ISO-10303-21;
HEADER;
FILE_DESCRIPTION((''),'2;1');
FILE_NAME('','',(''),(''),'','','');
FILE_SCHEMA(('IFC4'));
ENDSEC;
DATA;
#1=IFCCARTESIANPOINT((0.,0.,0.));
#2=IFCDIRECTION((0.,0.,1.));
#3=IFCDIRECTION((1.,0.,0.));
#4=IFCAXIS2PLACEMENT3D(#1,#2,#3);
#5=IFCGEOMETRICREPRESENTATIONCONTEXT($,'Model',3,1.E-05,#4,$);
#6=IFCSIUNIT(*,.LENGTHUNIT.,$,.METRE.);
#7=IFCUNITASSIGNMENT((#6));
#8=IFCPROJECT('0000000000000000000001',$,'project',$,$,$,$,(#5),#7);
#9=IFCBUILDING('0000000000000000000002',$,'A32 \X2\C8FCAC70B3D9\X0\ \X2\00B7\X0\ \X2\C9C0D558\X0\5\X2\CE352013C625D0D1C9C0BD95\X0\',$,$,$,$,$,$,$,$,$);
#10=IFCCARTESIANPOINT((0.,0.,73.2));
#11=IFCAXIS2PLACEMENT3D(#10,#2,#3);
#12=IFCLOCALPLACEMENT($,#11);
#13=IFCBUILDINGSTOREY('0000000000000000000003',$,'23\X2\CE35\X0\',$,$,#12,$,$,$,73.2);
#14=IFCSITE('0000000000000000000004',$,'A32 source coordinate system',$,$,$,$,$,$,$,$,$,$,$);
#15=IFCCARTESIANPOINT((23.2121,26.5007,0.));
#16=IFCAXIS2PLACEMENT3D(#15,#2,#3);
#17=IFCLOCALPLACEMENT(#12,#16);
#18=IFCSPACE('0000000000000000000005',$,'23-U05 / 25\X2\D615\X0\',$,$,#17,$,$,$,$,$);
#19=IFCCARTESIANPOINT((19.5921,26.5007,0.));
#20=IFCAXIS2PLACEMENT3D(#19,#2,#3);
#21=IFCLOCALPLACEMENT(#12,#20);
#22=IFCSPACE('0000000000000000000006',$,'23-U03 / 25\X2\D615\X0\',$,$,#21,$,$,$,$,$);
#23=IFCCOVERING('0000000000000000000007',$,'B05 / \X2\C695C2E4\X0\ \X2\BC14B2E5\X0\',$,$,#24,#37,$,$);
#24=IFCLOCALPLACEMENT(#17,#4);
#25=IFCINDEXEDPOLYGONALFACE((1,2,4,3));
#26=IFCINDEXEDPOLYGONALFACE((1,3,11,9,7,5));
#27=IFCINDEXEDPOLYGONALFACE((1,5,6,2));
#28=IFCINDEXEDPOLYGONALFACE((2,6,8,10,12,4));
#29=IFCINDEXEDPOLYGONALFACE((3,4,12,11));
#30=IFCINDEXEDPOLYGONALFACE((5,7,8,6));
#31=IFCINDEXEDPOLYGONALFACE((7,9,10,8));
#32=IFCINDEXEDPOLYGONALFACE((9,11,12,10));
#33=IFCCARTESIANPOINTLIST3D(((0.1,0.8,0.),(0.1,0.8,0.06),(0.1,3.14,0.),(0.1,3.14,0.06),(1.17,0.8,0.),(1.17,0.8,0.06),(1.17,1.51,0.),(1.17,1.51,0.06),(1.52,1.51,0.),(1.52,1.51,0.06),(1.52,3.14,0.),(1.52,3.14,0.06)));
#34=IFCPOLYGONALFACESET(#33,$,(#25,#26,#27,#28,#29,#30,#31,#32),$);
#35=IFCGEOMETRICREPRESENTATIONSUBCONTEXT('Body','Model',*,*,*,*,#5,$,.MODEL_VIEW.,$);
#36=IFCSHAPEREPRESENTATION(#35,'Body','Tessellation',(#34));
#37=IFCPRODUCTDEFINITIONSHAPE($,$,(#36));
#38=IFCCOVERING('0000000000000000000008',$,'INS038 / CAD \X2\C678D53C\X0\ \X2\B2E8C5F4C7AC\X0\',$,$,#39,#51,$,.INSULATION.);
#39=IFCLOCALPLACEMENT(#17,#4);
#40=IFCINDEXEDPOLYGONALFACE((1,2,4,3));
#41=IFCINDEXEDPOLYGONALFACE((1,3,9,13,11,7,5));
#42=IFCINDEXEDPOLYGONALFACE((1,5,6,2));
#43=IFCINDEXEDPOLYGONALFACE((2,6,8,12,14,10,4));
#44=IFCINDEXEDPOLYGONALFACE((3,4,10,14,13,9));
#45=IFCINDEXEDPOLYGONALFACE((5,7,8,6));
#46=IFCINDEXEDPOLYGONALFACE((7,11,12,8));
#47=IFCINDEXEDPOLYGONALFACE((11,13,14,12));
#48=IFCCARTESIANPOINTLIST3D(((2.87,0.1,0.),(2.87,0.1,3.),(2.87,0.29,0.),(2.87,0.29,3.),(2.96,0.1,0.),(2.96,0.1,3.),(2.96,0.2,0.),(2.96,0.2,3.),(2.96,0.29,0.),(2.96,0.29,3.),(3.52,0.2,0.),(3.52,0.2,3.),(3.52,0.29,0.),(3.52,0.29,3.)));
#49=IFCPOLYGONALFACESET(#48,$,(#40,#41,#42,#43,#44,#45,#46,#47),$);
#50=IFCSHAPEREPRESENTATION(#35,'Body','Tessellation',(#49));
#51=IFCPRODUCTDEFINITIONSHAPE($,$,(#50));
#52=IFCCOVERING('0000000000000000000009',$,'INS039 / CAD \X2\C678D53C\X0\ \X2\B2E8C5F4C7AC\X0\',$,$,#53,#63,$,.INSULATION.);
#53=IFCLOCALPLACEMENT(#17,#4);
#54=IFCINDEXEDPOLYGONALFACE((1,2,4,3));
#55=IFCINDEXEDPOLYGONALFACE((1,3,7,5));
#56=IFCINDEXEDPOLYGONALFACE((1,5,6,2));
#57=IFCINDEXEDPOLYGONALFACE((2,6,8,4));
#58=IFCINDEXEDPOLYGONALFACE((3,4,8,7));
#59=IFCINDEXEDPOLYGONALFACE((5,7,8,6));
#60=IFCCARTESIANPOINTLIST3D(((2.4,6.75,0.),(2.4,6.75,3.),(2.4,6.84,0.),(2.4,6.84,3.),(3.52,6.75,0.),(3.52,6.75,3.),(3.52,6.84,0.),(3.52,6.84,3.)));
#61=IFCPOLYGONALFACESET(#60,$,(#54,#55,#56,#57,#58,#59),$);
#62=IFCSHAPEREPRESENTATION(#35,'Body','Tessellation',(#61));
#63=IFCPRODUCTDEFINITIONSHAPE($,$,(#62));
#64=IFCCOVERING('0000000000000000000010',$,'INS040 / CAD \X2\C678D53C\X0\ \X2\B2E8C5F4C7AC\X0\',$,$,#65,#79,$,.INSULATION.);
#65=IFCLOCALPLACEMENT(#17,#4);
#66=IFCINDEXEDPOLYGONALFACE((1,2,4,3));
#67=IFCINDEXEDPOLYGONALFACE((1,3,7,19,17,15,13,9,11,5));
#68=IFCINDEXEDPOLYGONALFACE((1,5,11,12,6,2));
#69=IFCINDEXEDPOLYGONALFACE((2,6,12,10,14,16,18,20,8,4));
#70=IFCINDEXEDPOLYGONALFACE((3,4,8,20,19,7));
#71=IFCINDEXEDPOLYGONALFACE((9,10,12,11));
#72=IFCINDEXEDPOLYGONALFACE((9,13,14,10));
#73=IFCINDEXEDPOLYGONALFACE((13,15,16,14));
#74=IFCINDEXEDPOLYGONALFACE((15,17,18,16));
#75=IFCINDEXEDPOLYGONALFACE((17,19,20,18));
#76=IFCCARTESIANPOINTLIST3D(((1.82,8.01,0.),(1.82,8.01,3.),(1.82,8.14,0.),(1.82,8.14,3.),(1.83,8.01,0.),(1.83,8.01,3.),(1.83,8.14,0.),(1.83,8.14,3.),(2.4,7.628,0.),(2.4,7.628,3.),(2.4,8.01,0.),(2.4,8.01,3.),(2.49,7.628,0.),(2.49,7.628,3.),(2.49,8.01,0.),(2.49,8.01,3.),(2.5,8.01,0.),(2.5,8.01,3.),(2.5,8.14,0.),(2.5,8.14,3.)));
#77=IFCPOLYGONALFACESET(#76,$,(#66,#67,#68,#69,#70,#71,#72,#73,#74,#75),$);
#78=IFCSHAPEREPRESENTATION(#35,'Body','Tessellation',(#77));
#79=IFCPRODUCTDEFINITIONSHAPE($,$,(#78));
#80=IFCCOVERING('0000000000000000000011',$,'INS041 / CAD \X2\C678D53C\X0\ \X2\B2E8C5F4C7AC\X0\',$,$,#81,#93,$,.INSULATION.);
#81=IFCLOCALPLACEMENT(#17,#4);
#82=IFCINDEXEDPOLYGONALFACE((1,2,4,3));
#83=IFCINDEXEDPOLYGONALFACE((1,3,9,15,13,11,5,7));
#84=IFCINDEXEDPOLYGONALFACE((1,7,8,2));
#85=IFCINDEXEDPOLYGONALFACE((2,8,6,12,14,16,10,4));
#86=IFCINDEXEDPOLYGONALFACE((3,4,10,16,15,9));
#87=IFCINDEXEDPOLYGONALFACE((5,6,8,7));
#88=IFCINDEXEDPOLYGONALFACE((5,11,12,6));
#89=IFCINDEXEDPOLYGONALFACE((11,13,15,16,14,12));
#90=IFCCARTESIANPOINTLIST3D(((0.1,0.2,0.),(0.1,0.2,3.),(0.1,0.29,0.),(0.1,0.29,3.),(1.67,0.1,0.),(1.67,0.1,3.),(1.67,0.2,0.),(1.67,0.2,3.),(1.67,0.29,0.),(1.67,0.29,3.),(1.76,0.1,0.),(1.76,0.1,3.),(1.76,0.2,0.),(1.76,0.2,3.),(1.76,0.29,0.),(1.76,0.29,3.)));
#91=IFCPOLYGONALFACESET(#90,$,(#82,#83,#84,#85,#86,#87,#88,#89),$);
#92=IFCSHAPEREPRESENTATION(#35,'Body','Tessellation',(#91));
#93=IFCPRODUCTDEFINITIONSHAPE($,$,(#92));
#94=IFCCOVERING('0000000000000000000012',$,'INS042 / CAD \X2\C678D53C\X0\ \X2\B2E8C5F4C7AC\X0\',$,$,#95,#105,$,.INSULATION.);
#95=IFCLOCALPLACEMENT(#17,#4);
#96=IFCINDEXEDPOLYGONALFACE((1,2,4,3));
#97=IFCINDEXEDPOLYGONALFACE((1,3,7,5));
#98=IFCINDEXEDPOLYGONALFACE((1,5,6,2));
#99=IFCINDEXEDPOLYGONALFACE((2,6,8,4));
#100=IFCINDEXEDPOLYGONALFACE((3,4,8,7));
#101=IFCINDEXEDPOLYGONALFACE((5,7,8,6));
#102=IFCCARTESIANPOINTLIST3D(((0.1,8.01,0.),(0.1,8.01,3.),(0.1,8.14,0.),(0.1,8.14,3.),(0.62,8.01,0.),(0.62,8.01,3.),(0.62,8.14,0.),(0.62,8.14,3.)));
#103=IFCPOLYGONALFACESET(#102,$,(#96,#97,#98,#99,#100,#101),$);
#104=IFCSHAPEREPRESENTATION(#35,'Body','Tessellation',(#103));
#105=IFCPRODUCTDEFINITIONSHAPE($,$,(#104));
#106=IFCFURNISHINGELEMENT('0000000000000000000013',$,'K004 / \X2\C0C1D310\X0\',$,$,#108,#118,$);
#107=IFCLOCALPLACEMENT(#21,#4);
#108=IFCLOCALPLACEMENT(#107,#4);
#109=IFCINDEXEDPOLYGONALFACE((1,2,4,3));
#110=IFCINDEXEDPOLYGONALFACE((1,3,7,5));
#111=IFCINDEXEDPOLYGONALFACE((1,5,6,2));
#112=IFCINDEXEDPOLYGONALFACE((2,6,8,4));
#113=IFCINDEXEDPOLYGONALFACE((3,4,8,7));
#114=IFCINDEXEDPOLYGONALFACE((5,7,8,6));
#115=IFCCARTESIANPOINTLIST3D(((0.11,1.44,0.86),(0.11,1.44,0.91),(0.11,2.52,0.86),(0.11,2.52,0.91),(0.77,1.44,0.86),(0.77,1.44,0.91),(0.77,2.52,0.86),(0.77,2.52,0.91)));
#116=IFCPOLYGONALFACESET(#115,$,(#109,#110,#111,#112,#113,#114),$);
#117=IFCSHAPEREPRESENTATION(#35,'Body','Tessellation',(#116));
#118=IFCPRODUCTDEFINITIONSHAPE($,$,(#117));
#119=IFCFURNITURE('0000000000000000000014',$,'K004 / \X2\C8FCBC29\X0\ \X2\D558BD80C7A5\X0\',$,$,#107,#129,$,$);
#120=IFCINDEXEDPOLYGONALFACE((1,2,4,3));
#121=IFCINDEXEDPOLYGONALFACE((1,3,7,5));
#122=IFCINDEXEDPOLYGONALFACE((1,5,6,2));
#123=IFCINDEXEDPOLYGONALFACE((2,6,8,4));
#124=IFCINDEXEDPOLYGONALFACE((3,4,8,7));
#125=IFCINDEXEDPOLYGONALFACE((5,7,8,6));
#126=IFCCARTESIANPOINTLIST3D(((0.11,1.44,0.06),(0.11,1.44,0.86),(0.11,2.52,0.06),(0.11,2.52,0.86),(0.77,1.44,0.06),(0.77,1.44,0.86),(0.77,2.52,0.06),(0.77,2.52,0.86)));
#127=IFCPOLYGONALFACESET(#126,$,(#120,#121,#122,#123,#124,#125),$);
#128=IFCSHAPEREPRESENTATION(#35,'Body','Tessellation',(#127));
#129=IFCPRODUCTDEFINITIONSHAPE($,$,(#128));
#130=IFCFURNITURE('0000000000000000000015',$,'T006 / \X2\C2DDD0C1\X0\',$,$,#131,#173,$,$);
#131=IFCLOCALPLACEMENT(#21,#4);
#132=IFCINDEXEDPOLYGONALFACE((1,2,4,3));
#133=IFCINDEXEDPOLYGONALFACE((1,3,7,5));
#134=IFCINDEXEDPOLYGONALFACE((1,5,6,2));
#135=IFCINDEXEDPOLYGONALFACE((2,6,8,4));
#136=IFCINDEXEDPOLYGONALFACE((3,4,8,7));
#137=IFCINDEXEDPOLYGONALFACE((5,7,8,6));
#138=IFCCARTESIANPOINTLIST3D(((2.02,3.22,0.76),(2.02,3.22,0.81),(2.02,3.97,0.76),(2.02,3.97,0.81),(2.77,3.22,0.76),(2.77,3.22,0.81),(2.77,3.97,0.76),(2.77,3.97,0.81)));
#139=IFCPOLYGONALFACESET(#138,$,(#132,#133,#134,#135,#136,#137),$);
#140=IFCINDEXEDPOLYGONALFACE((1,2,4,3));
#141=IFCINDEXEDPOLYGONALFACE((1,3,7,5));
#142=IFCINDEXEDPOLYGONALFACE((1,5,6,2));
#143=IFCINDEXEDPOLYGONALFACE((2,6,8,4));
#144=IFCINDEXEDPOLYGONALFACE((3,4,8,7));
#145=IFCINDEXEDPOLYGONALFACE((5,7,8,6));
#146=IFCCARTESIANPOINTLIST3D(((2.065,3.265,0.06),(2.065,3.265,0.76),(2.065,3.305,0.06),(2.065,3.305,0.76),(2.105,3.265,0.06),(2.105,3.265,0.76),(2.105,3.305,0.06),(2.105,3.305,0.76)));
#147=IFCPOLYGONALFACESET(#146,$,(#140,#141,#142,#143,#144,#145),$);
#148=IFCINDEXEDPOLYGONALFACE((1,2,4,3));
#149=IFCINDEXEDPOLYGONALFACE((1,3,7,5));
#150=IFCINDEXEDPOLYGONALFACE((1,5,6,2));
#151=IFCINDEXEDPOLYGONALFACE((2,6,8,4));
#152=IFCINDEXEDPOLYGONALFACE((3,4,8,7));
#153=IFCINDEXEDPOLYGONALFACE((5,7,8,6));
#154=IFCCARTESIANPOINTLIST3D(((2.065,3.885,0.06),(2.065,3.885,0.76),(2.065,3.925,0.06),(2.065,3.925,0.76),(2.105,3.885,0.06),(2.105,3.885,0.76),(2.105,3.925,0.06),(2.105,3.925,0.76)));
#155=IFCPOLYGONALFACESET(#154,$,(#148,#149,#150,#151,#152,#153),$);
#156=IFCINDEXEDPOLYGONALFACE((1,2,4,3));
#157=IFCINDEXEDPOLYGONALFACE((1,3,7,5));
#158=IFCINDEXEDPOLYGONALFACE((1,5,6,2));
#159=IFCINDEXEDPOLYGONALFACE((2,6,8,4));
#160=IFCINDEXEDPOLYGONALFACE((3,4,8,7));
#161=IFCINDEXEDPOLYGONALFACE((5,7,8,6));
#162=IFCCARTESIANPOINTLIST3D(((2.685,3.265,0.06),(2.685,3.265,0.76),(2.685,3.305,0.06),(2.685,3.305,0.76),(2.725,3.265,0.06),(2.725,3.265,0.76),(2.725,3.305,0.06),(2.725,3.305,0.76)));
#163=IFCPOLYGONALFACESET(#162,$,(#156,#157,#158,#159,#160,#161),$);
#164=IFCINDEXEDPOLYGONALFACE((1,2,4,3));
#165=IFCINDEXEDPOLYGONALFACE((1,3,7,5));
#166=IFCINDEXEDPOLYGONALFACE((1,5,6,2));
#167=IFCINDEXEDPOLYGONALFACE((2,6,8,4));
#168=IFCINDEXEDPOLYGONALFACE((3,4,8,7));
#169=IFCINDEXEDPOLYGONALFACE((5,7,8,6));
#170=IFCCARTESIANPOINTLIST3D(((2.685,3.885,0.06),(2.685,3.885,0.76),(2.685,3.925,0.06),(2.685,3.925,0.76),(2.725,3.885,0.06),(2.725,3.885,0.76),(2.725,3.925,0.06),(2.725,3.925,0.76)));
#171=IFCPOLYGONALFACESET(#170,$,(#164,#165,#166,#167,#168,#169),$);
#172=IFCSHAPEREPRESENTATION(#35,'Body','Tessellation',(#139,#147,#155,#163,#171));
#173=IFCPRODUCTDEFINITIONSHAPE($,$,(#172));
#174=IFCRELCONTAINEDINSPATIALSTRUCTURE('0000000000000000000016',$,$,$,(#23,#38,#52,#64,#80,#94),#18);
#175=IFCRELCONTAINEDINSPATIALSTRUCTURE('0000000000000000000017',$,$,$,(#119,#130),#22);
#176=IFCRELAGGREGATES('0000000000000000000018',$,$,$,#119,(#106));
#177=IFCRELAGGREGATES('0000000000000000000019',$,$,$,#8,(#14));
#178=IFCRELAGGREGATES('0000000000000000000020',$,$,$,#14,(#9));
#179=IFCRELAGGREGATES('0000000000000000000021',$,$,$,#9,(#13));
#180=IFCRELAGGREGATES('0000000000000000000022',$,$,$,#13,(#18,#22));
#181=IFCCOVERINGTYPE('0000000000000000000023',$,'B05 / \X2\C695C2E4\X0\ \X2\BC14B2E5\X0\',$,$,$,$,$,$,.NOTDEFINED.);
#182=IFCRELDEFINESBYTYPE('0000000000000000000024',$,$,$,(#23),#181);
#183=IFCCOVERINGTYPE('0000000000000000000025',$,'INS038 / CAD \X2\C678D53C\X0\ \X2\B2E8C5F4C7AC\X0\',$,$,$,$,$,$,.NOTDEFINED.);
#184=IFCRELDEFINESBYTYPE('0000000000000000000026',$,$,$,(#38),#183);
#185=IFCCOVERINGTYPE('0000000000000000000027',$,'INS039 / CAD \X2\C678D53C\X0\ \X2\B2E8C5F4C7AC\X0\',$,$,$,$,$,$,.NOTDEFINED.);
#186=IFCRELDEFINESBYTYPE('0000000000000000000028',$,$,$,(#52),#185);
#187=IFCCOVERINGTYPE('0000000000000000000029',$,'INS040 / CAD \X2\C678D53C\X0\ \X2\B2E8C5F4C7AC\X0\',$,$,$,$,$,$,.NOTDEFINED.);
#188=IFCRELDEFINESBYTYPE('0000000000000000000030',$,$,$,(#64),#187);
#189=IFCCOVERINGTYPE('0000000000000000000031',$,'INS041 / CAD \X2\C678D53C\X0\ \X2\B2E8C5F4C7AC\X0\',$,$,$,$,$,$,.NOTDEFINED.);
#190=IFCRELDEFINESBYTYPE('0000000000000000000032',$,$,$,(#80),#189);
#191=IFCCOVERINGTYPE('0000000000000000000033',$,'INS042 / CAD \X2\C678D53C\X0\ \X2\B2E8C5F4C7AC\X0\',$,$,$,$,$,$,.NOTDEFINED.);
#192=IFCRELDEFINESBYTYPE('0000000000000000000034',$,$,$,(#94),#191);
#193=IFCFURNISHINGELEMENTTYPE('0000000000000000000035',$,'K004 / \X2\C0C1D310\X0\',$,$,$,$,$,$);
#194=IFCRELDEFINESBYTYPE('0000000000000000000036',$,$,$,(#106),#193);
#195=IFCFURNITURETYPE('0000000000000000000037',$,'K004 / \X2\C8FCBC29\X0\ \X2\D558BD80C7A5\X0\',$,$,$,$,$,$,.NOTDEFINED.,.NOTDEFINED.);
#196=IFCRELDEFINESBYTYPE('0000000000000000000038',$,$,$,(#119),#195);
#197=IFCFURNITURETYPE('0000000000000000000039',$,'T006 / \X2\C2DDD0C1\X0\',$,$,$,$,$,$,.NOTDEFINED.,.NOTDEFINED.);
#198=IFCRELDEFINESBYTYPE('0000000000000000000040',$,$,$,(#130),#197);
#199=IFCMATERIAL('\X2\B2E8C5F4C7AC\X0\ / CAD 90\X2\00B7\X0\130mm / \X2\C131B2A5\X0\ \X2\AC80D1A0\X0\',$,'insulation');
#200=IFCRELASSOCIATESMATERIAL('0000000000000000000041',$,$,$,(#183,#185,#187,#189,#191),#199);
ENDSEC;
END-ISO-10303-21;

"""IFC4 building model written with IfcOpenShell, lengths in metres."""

from ifc_helpers import new_model, si_unit, frame, origin, origin_with_axes, place, context, subcontext, project, spatial, polyline, outline, extrude, source, transform, mapped, material, type_object, type_shapes, element, aggregate, save


model = new_model("IFC4")

# Units and contexts
model_context = context("Model", 3, precision=1e-05, world=origin_with_axes())
body_context = subcontext(model_context, "Body", "Model", "MODEL_VIEW")
ifc_project = project(units=[si_unit("LENGTHUNIT", "METRE")], contexts=[model_context])

# Site, building, storey, space
storey_placement = place(None, frame((0.0, 0.0, 73.2), z_axis=(0.0, 0.0, 1.0), x_axis=(1.0, 0.0, 0.0)))
space_1_placement = place(storey_placement, frame((23.2121, 26.5007, 0.0), z_axis=(0.0, 0.0, 1.0), x_axis=(1.0, 0.0, 0.0)))
site = spatial("IfcSite", under=ifc_project, Name="A32 source coordinate system")
building = spatial("IfcBuilding", under=site, Name="A32 주거동 · 지하5층–옥탑지붕")
storey = spatial("IfcBuildingStorey", under=building, at=storey_placement, Name="23층", Elevation=73.2)
space_1 = spatial("IfcSpace", under=storey, at=space_1_placement, Name="23-U05 / 25형")

# Shared definitions
space_2_placement = place(storey_placement, frame((19.5921, 26.5007, 0.0), z_axis=(0.0, 0.0, 1.0), x_axis=(1.0, 0.0, 0.0)))
space_2 = spatial("IfcSpace", under=storey, at=space_2_placement, Name="23-U03 / 25형")

# Coverings
covering_type_1 = type_object("IfcCoveringType", Name="B05 / 욕실 바닥", PredefinedType="NOTDEFINED")
shared_shape_1 = source(origin(), body_context, "Body", "SweptSolid", [
    extrude(outline(polyline([(0.1, 3.14), (1.52, 3.14), (1.52, 1.51), (1.17, 1.51), (1.17, 0.8), (0.1, 0.8), (0.1, 3.14)])), origin(), (0.0, 0.0, 1.0), 0.06),
])
type_shapes(covering_type_1, [shared_shape_1])
covering_1_placement = place(space_1_placement, origin_with_axes())
element("IfcCovering", 1, at=covering_1_placement, inside=space_1, type_object=covering_type_1, Name="B05 / 욕실 바닥", context=body_context, shape_type="MappedRepresentation", body=[
    mapped(shared_shape_1, transform((0.0, 0.0, 0.0), scale=1.0)),
])
ifc_material = material(Name="단열재 / CAD 90·130mm / 성능 검토", Category="insulation")
covering_type_2 = type_object("IfcCoveringType", Name="INS038 / CAD 외피 단열재", PredefinedType="NOTDEFINED", material=ifc_material)
shared_shape_2 = source(origin(), body_context, "Body", "SweptSolid", [
    extrude(outline(polyline([(2.96, 0.2), (2.96, 0.1), (2.87, 0.1), (2.87, 0.29), (2.96, 0.29), (3.52, 0.29), (3.52, 0.2), (2.96, 0.2)])), origin(), (0.0, 0.0, 1.0), 3.0),
])
type_shapes(covering_type_2, [shared_shape_2])
covering_2_placement = place(space_1_placement, origin_with_axes())
element("IfcCovering", 2, at=covering_2_placement, inside=space_1, type_object=covering_type_2, Name="INS038 / CAD 외피 단열재", PredefinedType="INSULATION", context=body_context, shape_type="MappedRepresentation", body=[
    mapped(shared_shape_2, transform((0.0, 0.0, 0.0), scale=1.0)),
])
covering_type_3 = type_object("IfcCoveringType", Name="INS039 / CAD 외피 단열재", PredefinedType="NOTDEFINED", material=ifc_material)
shared_shape_3 = source(origin(), body_context, "Body", "SweptSolid", [
    extrude(outline(polyline([(2.4, 6.75), (2.4, 6.84), (3.52, 6.84), (3.52, 6.75), (2.4, 6.75)])), origin(), (0.0, 0.0, 1.0), 3.0),
])
type_shapes(covering_type_3, [shared_shape_3])
covering_3_placement = place(space_1_placement, origin_with_axes())
element("IfcCovering", 3, at=covering_3_placement, inside=space_1, type_object=covering_type_3, Name="INS039 / CAD 외피 단열재", PredefinedType="INSULATION", context=body_context, shape_type="MappedRepresentation", body=[
    mapped(shared_shape_3, transform((0.0, 0.0, 0.0), scale=1.0)),
])
covering_type_4 = type_object("IfcCoveringType", Name="INS040 / CAD 외피 단열재", PredefinedType="NOTDEFINED", material=ifc_material)
shared_shape_4 = source(origin(), body_context, "Body", "SweptSolid", [
    extrude(outline(polyline([(2.4, 7.628), (2.4, 8.01), (1.83, 8.01), (1.82, 8.01), (1.82, 8.14), (1.83, 8.14), (2.5, 8.14), (2.5, 8.01), (2.49, 8.01), (2.49, 7.628), (2.4, 7.628)])), origin(), (0.0, 0.0, 1.0), 3.0),
])
type_shapes(covering_type_4, [shared_shape_4])
covering_4_placement = place(space_1_placement, origin_with_axes())
element("IfcCovering", 4, at=covering_4_placement, inside=space_1, type_object=covering_type_4, Name="INS040 / CAD 외피 단열재", PredefinedType="INSULATION", context=body_context, shape_type="MappedRepresentation", body=[
    mapped(shared_shape_4, transform((0.0, 0.0, 0.0), scale=1.0)),
])
covering_type_5 = type_object("IfcCoveringType", Name="INS041 / CAD 외피 단열재", PredefinedType="NOTDEFINED", material=ifc_material)
shared_shape_5 = source(origin(), body_context, "Body", "SweptSolid", [
    extrude(outline(polyline([(1.67, 0.2), (0.1, 0.2), (0.1, 0.29), (1.67, 0.29), (1.76, 0.29), (1.76, 0.2), (1.76, 0.1), (1.67, 0.1), (1.67, 0.2)])), origin(), (0.0, 0.0, 1.0), 3.0),
])
type_shapes(covering_type_5, [shared_shape_5])
covering_5_placement = place(space_1_placement, origin_with_axes())
element("IfcCovering", 5, at=covering_5_placement, inside=space_1, type_object=covering_type_5, Name="INS041 / CAD 외피 단열재", PredefinedType="INSULATION", context=body_context, shape_type="MappedRepresentation", body=[
    mapped(shared_shape_5, transform((0.0, 0.0, 0.0), scale=1.0)),
])
covering_type_6 = type_object("IfcCoveringType", Name="INS042 / CAD 외피 단열재", PredefinedType="NOTDEFINED", material=ifc_material)
shared_shape_6 = source(origin(), body_context, "Body", "SweptSolid", [
    extrude(outline(polyline([(0.62, 8.14), (0.62, 8.01), (0.1, 8.01), (0.1, 8.14), (0.62, 8.14)])), origin(), (0.0, 0.0, 1.0), 3.0),
])
type_shapes(covering_type_6, [shared_shape_6])
covering_6_placement = place(space_1_placement, origin_with_axes())
element("IfcCovering", 6, at=covering_6_placement, inside=space_1, type_object=covering_type_6, Name="INS042 / CAD 외피 단열재", PredefinedType="INSULATION", context=body_context, shape_type="MappedRepresentation", body=[
    mapped(shared_shape_6, transform((0.0, 0.0, 0.0), scale=1.0)),
])

# Furnishing element
furnishing_element_type_1 = type_object("IfcFurnishingElementType", Name="K004 / 상판")
shared_shape_7 = source(origin(), body_context, "Body", "SweptSolid", [
    extrude(outline(polyline([(0.77, 2.52), (0.77, 1.44), (0.11, 1.44), (0.11, 2.52), (0.77, 2.52)])), frame((0.0, 0.0, 0.86)), (0.0, 0.0, 1.0), 0.05),
])
type_shapes(furnishing_element_type_1, [shared_shape_7])
furniture_1_placement = place(space_2_placement, origin_with_axes())
furnishing_1_placement = place(furniture_1_placement, origin_with_axes())
furnishing_1 = element("IfcFurnishingElement", 7, at=furnishing_1_placement, type_object=furnishing_element_type_1, Name="K004 / 상판", context=body_context, shape_type="MappedRepresentation", body=[
    mapped(shared_shape_7, transform((0.0, 0.0, 0.0), scale=1.0)),
])

# Furniture
furniture_type_1 = type_object("IfcFurnitureType", Name="K004 / 주방 하부장", AssemblyPlace="NOTDEFINED", PredefinedType="NOTDEFINED")
shared_shape_8 = source(origin(), body_context, "Body", "SweptSolid", [
    extrude(outline(polyline([(0.11, 2.52), (0.77, 2.52), (0.77, 1.44), (0.11, 1.44), (0.11, 2.52)])), frame((0.0, 0.0, 0.06)), (0.0, 0.0, 1.0), 0.8),
])
type_shapes(furniture_type_1, [shared_shape_8])
furniture_1 = element("IfcFurniture", 8, at=furniture_1_placement, inside=space_2, type_object=furniture_type_1, Name="K004 / 주방 하부장", context=body_context, shape_type="MappedRepresentation", body=[
    mapped(shared_shape_8, transform((0.0, 0.0, 0.0), scale=1.0)),
])
aggregate(furniture_1, [furnishing_1])
furniture_type_2 = type_object("IfcFurnitureType", Name="T006 / 식탁", AssemblyPlace="NOTDEFINED", PredefinedType="NOTDEFINED")
shared_shape_9 = source(origin(), body_context, "Body", "SweptSolid", [
    extrude(outline(polyline([(2.77, 3.22), (2.02, 3.22), (2.02, 3.97), (2.77, 3.97), (2.77, 3.22)])), frame((0.0, 0.0, 0.76)), (0.0, 0.0, 1.0), 0.05),
    extrude(outline(polyline([(2.065, 3.265), (2.065, 3.305), (2.105, 3.305), (2.105, 3.265), (2.065, 3.265)])), frame((0.0, 0.0, 0.06)), (0.0, 0.0, 1.0), 0.7),
    extrude(outline(polyline([(2.065, 3.885), (2.065, 3.925), (2.105, 3.925), (2.105, 3.885), (2.065, 3.885)])), frame((0.0, 0.0, 0.06)), (0.0, 0.0, 1.0), 0.7),
    extrude(outline(polyline([(2.685, 3.265), (2.685, 3.305), (2.725, 3.305), (2.725, 3.265), (2.685, 3.265)])), frame((0.0, 0.0, 0.06)), (0.0, 0.0, 1.0), 0.7),
    extrude(outline(polyline([(2.685, 3.885), (2.685, 3.925), (2.725, 3.925), (2.725, 3.885), (2.685, 3.885)])), frame((0.0, 0.0, 0.06)), (0.0, 0.0, 1.0), 0.7),
])
type_shapes(furniture_type_2, [shared_shape_9])
furniture_2_placement = place(space_2_placement, origin_with_axes())
element("IfcFurniture", 9, at=furniture_2_placement, inside=space_2, type_object=furniture_type_2, Name="T006 / 식탁", context=body_context, shape_type="MappedRepresentation", body=[
    mapped(shared_shape_9, transform((0.0, 0.0, 0.0), scale=1.0)),
])

save(model, "model.ifc")
